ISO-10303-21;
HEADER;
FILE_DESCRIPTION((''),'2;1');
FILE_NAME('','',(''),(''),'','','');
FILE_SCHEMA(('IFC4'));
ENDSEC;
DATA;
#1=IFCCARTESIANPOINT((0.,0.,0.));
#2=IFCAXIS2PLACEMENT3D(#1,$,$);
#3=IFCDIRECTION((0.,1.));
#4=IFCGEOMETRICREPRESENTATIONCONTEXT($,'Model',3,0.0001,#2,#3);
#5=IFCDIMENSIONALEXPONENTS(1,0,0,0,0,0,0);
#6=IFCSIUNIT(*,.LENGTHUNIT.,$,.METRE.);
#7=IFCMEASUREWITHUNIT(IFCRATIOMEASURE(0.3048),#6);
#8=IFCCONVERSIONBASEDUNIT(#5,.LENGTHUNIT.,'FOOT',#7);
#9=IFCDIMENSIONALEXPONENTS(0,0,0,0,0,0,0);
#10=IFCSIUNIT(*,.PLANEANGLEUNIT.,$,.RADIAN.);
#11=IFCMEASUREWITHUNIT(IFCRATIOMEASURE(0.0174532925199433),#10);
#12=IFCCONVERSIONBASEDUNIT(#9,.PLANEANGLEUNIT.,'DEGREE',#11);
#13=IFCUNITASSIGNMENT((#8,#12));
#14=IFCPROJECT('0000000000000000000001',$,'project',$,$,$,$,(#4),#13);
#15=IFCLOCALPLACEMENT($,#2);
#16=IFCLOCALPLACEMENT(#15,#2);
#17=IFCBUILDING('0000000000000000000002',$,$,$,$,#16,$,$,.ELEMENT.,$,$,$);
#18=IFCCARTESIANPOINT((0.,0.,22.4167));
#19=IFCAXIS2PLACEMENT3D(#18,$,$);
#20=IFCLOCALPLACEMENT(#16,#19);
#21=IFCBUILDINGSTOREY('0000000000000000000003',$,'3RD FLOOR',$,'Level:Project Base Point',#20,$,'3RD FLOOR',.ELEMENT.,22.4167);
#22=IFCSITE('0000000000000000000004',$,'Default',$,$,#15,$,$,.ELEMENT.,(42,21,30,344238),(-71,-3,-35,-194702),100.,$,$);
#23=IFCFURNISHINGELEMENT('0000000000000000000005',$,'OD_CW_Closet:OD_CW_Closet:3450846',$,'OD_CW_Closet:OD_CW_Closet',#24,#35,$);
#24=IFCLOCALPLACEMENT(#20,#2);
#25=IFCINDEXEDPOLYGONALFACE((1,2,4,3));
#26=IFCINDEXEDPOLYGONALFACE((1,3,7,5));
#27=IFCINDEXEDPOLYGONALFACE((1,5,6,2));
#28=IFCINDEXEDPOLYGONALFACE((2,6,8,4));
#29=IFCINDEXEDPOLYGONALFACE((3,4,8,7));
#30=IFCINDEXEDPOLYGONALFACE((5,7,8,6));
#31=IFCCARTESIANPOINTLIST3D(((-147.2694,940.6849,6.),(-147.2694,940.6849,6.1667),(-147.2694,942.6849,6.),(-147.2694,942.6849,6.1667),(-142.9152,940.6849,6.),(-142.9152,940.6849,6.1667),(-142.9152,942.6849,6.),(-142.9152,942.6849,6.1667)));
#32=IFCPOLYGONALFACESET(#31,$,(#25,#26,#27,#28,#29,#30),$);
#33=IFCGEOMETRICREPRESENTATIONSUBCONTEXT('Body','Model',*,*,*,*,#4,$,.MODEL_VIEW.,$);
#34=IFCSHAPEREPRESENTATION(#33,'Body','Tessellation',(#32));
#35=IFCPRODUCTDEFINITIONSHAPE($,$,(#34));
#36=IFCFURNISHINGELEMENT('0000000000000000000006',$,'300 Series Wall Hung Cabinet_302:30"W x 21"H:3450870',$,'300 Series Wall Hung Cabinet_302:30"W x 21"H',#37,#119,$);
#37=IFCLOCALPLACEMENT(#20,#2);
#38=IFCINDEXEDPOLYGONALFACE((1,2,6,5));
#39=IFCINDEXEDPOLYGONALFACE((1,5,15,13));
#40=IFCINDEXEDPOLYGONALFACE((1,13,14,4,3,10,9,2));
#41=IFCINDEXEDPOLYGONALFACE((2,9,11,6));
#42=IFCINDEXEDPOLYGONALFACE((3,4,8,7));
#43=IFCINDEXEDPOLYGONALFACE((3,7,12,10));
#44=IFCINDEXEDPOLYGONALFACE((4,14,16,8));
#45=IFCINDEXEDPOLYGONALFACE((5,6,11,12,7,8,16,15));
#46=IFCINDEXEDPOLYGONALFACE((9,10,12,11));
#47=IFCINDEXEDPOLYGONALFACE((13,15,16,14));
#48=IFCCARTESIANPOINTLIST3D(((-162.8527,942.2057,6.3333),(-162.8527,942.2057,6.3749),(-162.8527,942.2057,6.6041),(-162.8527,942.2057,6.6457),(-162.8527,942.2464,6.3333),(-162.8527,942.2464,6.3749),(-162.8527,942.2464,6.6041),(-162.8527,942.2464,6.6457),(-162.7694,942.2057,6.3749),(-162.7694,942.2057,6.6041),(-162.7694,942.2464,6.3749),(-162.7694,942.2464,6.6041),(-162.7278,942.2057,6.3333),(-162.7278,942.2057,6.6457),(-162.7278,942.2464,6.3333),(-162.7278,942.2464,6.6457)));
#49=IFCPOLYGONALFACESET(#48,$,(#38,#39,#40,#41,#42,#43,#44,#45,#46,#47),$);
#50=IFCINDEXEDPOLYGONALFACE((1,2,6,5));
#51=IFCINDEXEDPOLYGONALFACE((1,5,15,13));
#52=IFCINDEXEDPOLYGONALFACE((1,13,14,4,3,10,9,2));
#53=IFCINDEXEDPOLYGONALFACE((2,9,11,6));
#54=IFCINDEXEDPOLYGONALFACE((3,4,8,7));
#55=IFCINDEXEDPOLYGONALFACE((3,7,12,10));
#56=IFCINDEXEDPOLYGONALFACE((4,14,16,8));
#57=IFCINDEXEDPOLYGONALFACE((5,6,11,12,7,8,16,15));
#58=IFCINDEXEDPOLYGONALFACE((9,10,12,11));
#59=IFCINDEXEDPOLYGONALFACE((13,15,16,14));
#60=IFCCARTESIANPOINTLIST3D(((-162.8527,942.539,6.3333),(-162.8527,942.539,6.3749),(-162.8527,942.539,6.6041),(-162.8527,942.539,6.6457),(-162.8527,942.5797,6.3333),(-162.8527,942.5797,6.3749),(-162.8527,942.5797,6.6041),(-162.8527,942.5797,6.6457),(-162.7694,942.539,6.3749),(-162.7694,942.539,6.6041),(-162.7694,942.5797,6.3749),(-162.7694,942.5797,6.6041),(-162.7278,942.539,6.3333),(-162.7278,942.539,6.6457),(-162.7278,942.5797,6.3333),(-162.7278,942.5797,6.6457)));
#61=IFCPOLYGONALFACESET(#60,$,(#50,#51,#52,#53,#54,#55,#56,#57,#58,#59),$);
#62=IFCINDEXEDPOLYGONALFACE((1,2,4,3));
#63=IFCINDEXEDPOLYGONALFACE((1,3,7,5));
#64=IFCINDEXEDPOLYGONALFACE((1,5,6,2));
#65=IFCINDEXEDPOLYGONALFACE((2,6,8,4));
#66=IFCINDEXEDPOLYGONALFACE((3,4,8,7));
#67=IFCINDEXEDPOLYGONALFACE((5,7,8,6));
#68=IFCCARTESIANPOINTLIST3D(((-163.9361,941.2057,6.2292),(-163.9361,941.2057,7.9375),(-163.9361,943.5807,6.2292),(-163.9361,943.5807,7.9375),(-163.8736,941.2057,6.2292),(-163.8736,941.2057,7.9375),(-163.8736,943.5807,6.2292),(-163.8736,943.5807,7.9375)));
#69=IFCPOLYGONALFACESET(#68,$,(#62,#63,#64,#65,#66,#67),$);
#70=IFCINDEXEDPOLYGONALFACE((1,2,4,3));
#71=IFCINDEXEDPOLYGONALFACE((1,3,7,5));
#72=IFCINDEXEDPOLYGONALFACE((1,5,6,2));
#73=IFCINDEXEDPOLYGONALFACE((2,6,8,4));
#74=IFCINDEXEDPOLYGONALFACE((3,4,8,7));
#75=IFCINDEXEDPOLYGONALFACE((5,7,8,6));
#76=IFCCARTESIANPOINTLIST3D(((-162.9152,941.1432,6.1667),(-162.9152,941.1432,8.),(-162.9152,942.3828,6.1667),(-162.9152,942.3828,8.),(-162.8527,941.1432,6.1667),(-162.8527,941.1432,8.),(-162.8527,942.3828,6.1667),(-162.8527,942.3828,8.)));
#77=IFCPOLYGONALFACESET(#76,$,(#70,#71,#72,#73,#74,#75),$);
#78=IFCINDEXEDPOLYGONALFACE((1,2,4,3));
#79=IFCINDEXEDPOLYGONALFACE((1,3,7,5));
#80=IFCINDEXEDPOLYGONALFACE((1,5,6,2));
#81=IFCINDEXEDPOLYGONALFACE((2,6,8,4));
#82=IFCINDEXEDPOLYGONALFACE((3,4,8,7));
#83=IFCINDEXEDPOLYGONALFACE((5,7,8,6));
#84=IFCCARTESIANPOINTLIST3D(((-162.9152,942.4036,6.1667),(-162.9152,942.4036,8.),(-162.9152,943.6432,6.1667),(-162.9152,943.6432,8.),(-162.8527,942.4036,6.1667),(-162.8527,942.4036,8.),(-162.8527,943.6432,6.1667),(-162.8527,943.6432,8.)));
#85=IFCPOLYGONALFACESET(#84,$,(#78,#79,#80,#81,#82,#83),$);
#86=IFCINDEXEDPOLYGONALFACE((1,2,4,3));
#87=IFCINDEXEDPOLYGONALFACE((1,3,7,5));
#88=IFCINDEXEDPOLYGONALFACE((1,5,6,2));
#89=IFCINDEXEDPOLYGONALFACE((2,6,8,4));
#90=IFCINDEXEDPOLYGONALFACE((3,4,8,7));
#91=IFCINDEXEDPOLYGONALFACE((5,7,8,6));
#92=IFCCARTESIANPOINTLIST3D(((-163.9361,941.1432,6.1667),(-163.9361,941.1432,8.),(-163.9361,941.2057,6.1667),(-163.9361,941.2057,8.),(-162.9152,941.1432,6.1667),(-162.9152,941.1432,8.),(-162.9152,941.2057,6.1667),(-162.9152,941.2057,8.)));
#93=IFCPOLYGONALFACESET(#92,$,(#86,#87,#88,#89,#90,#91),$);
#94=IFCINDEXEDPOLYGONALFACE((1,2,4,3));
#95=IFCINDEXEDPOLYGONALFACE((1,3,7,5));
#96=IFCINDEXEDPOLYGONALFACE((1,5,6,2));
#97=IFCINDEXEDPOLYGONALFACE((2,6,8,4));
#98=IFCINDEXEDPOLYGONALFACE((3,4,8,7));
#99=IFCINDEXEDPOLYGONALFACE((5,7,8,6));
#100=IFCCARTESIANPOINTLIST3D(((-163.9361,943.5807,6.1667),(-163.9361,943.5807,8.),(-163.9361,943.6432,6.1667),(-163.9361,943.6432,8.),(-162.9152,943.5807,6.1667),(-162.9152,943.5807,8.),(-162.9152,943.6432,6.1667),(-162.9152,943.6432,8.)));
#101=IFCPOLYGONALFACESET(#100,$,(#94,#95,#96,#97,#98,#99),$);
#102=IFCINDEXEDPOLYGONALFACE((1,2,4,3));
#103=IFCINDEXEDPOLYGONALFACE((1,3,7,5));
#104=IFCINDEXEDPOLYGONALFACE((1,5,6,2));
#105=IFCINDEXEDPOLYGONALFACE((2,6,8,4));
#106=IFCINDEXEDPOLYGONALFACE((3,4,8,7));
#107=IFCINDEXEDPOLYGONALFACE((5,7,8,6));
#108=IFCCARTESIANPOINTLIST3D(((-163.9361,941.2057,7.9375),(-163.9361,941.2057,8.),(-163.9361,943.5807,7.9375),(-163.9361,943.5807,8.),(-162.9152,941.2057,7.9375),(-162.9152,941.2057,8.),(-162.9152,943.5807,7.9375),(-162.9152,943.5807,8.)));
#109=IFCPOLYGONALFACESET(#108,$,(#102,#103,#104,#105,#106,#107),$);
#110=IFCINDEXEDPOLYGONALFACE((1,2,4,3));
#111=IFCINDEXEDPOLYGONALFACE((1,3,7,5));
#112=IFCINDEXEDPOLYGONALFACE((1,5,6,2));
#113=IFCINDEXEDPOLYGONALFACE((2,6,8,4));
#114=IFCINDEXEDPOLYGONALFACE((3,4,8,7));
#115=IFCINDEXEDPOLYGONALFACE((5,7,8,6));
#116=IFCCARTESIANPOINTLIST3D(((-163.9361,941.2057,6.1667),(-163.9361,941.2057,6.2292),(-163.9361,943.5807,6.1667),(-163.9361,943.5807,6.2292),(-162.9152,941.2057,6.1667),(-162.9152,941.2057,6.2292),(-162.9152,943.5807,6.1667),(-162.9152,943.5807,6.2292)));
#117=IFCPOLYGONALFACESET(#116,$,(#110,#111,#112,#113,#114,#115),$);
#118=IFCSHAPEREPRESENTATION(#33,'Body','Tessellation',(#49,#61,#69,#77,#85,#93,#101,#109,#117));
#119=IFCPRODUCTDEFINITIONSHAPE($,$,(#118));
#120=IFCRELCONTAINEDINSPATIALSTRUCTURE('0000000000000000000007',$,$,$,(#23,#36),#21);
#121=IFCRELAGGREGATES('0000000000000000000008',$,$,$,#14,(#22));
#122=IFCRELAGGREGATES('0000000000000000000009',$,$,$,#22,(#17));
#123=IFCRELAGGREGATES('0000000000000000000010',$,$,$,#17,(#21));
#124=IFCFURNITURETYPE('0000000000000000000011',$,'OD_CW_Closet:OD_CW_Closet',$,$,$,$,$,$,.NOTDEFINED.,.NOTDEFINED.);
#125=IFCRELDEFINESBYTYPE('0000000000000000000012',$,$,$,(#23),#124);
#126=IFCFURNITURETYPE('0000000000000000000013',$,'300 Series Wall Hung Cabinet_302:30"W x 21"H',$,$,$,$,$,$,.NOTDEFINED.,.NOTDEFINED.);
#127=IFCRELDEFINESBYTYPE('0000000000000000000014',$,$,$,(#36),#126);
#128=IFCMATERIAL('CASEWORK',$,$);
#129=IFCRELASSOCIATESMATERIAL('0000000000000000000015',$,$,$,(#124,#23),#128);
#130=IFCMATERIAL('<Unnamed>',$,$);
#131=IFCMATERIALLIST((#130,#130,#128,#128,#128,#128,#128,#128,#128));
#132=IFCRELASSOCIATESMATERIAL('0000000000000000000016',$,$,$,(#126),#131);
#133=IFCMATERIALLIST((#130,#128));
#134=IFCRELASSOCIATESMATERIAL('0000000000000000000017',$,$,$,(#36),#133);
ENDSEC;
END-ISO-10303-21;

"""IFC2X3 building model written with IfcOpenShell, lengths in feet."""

from ifc_helpers import new_model, entity, si_unit, converted_unit, direction, frame, frame_2d, origin, origin_2d_with_axis, place, context, subcontext, project, spatial, polyline, rectangle, outline, extrude, source, transform, mapped, material, material_list, type_object, type_shapes, element, save


model = new_model("IFC2X3")

# Units and contexts
model_context = context("Model", 3, precision=0.0001, world=origin(), true_north=direction((0.0, 1.0)))
body_context = subcontext(model_context, "Body", "Model", "MODEL_VIEW")
ifc_project = project(units=[converted_unit("LENGTHUNIT", "FOOT", entity("IfcRatioMeasure", 0.3048), si_unit("LENGTHUNIT", "METRE"), dimensions=[1, 0, 0, 0, 0, 0, 0]), converted_unit("PLANEANGLEUNIT", "DEGREE", entity("IfcRatioMeasure", 0.0174532925199433), si_unit("PLANEANGLEUNIT", "RADIAN"), dimensions=[0, 0, 0, 0, 0, 0, 0])], contexts=[model_context])

# Site, building, storey
site_placement = place(None, origin())
site = spatial("IfcSite", under=ifc_project, at=site_placement, Name="Default", CompositionType="ELEMENT", RefLatitude=(42, 21, 30, 344238), RefLongitude=(-71, -3, -35, -194702), RefElevation=100.0)
building_placement = place(site_placement, origin())
building = spatial("IfcBuilding", under=site, at=building_placement, CompositionType="ELEMENT")
storey_placement = place(building_placement, frame((0.0, 0.0, 22.4167)))
storey = spatial("IfcBuildingStorey", under=building, at=storey_placement, Name="3RD FLOOR", ObjectType="Level:Project Base Point", LongName="3RD FLOOR", CompositionType="ELEMENT", Elevation=22.4167)

# Furnishing elements
ifc_material_1 = material(Name="CASEWORK")
furniture_type_1 = type_object("IfcFurnitureType", Name="OD_CW_Closet:OD_CW_Closet", material=ifc_material_1)
shared_shape_1 = source(origin(), body_context, "Body", "SweptSolid", [
    extrude(rectangle(XDim=4.3542, YDim=2.0, at=frame_2d((0.0, 0.0), x_axis=(1.0, 0.0))), frame((2.1771, 1.0, 0.0)), (0.0, 0.0, 1.0), 0.1667),
])
type_shapes(furniture_type_1, [shared_shape_1])
furnishing_1_placement = place(storey_placement, frame((-142.9152, 942.6849, 6.0), z_axis=(0.0, 0.0, 1.0), x_axis=(-1.0, 0.0, 0.0)))
element("IfcFurnishingElement", 1, at=furnishing_1_placement, inside=storey, type_object=furniture_type_1, material=ifc_material_1, Name="OD_CW_Closet:OD_CW_Closet:3450846", ObjectType="OD_CW_Closet:OD_CW_Closet", context=body_context, shape_type="MappedRepresentation", body=[
    mapped(shared_shape_1, transform((0.0, 0.0, 0.0), scale=1.0)),
])
ifc_material_2 = material(Name="<Unnamed>")
ifc_material_list_1 = material_list([ifc_material_2, ifc_material_1])
ifc_material_list_2 = material_list([ifc_material_2, ifc_material_2, ifc_material_1, ifc_material_1, ifc_material_1, ifc_material_1, ifc_material_1, ifc_material_1, ifc_material_1])
furniture_type_2 = type_object("IfcFurnitureType", Name="300 Series Wall Hung Cabinet_302:30\"W x 21\"H", material=ifc_material_list_2)
shared_shape_2 = source(origin(), body_context, "Body", "SweptSolid", [
    extrude(outline(polyline([(0.1146, -0.0521), (0.1562, -0.0521), (0.1562, 0.0729), (-0.1562, 0.0729), (-0.1562, -0.0521), (-0.1146, -0.0521), (-0.1146, 0.0313), (0.1146, 0.0313), (0.1146, -0.0521)])), frame((1.0625, 0.0729, 0.3229), z_axis=(1.0, 0.0, 0.0), x_axis=(0.0, 0.0, 1.0)), (0.0, 0.0, 1.0), 0.0407),
    extrude(outline(polyline([(0.1146, -0.0521), (0.1562, -0.0521), (0.1562, 0.0729), (-0.1562, 0.0729), (-0.1562, -0.0521), (-0.1146, -0.0521), (-0.1146, 0.0313), (0.1146, 0.0313), (0.1146, -0.0521)])), frame((1.3958, 0.0729, 0.3229), z_axis=(1.0, 0.0, 0.0), x_axis=(0.0, 0.0, 1.0)), (0.0, 0.0, 1.0), 0.0407),
    extrude(rectangle(XDim=2.375, YDim=0.0625, at=origin_2d_with_axis()), frame((1.25, 1.177, 0.0625), z_axis=(0.0, 0.0, 1.0), x_axis=(-1.0, 0.0, 0.0)), (0.0, 0.0, 1.0), 1.7083),
    extrude(rectangle(XDim=1.2396, YDim=0.0625, at=origin_2d_with_axis()), frame((0.6198, 0.1562, 0.0), z_axis=(0.0, 0.0, 1.0), x_axis=(-1.0, 0.0, 0.0)), (0.0, 0.0, 1.0), 1.8333),
    extrude(rectangle(XDim=1.2396, YDim=0.0625, at=origin_2d_with_axis()), frame((1.8802, 0.1562, 0.0), z_axis=(0.0, 0.0, 1.0), x_axis=(-1.0, 0.0, 0.0)), (0.0, 0.0, 1.0), 1.8333),
    extrude(rectangle(XDim=1.0208, YDim=0.0625, at=frame_2d((0.0, 0.0), x_axis=(1.0, 0.0))), frame((0.0313, 0.6979, 0.0), z_axis=(0.0, 0.0, 1.0), x_axis=(0.0, -1.0, 0.0)), (0.0, 0.0, 1.0), 1.8333),
    extrude(rectangle(XDim=1.0208, YDim=0.0625, at=frame_2d((0.0, 0.0), x_axis=(1.0, 0.0))), frame((2.4688, 0.6979, 0.0), z_axis=(0.0, 0.0, 1.0), x_axis=(0.0, -1.0, 0.0)), (0.0, 0.0, 1.0), 1.8333),
    extrude(rectangle(XDim=1.0208, YDim=2.375, at=origin_2d_with_axis()), frame((1.25, 0.6979, 1.7708), z_axis=(0.0, 0.0, 1.0), x_axis=(0.0, 1.0, 0.0)), (0.0, 0.0, 1.0), 0.0625),
    extrude(rectangle(XDim=1.0208, YDim=2.375, at=origin_2d_with_axis()), frame((1.25, 0.6979, 0.0), z_axis=(0.0, 0.0, 1.0), x_axis=(0.0, 1.0, 0.0)), (0.0, 0.0, 1.0), 0.0625),
])
type_shapes(furniture_type_2, [shared_shape_2])
furnishing_2_placement = place(storey_placement, frame((-162.7278, 941.1432, 6.1667), z_axis=(0.0, 0.0, 1.0), x_axis=(0.0, 1.0, 0.0)))
element("IfcFurnishingElement", 2, at=furnishing_2_placement, inside=storey, type_object=furniture_type_2, material=ifc_material_list_1, Name="300 Series Wall Hung Cabinet_302:30\"W x 21\"H:3450870", ObjectType="300 Series Wall Hung Cabinet_302:30\"W x 21\"H", context=body_context, shape_type="MappedRepresentation", body=[
    mapped(shared_shape_2, transform((0.0, 0.0, 0.0), scale=1.0)),
])

save(model, "model.ifc")
